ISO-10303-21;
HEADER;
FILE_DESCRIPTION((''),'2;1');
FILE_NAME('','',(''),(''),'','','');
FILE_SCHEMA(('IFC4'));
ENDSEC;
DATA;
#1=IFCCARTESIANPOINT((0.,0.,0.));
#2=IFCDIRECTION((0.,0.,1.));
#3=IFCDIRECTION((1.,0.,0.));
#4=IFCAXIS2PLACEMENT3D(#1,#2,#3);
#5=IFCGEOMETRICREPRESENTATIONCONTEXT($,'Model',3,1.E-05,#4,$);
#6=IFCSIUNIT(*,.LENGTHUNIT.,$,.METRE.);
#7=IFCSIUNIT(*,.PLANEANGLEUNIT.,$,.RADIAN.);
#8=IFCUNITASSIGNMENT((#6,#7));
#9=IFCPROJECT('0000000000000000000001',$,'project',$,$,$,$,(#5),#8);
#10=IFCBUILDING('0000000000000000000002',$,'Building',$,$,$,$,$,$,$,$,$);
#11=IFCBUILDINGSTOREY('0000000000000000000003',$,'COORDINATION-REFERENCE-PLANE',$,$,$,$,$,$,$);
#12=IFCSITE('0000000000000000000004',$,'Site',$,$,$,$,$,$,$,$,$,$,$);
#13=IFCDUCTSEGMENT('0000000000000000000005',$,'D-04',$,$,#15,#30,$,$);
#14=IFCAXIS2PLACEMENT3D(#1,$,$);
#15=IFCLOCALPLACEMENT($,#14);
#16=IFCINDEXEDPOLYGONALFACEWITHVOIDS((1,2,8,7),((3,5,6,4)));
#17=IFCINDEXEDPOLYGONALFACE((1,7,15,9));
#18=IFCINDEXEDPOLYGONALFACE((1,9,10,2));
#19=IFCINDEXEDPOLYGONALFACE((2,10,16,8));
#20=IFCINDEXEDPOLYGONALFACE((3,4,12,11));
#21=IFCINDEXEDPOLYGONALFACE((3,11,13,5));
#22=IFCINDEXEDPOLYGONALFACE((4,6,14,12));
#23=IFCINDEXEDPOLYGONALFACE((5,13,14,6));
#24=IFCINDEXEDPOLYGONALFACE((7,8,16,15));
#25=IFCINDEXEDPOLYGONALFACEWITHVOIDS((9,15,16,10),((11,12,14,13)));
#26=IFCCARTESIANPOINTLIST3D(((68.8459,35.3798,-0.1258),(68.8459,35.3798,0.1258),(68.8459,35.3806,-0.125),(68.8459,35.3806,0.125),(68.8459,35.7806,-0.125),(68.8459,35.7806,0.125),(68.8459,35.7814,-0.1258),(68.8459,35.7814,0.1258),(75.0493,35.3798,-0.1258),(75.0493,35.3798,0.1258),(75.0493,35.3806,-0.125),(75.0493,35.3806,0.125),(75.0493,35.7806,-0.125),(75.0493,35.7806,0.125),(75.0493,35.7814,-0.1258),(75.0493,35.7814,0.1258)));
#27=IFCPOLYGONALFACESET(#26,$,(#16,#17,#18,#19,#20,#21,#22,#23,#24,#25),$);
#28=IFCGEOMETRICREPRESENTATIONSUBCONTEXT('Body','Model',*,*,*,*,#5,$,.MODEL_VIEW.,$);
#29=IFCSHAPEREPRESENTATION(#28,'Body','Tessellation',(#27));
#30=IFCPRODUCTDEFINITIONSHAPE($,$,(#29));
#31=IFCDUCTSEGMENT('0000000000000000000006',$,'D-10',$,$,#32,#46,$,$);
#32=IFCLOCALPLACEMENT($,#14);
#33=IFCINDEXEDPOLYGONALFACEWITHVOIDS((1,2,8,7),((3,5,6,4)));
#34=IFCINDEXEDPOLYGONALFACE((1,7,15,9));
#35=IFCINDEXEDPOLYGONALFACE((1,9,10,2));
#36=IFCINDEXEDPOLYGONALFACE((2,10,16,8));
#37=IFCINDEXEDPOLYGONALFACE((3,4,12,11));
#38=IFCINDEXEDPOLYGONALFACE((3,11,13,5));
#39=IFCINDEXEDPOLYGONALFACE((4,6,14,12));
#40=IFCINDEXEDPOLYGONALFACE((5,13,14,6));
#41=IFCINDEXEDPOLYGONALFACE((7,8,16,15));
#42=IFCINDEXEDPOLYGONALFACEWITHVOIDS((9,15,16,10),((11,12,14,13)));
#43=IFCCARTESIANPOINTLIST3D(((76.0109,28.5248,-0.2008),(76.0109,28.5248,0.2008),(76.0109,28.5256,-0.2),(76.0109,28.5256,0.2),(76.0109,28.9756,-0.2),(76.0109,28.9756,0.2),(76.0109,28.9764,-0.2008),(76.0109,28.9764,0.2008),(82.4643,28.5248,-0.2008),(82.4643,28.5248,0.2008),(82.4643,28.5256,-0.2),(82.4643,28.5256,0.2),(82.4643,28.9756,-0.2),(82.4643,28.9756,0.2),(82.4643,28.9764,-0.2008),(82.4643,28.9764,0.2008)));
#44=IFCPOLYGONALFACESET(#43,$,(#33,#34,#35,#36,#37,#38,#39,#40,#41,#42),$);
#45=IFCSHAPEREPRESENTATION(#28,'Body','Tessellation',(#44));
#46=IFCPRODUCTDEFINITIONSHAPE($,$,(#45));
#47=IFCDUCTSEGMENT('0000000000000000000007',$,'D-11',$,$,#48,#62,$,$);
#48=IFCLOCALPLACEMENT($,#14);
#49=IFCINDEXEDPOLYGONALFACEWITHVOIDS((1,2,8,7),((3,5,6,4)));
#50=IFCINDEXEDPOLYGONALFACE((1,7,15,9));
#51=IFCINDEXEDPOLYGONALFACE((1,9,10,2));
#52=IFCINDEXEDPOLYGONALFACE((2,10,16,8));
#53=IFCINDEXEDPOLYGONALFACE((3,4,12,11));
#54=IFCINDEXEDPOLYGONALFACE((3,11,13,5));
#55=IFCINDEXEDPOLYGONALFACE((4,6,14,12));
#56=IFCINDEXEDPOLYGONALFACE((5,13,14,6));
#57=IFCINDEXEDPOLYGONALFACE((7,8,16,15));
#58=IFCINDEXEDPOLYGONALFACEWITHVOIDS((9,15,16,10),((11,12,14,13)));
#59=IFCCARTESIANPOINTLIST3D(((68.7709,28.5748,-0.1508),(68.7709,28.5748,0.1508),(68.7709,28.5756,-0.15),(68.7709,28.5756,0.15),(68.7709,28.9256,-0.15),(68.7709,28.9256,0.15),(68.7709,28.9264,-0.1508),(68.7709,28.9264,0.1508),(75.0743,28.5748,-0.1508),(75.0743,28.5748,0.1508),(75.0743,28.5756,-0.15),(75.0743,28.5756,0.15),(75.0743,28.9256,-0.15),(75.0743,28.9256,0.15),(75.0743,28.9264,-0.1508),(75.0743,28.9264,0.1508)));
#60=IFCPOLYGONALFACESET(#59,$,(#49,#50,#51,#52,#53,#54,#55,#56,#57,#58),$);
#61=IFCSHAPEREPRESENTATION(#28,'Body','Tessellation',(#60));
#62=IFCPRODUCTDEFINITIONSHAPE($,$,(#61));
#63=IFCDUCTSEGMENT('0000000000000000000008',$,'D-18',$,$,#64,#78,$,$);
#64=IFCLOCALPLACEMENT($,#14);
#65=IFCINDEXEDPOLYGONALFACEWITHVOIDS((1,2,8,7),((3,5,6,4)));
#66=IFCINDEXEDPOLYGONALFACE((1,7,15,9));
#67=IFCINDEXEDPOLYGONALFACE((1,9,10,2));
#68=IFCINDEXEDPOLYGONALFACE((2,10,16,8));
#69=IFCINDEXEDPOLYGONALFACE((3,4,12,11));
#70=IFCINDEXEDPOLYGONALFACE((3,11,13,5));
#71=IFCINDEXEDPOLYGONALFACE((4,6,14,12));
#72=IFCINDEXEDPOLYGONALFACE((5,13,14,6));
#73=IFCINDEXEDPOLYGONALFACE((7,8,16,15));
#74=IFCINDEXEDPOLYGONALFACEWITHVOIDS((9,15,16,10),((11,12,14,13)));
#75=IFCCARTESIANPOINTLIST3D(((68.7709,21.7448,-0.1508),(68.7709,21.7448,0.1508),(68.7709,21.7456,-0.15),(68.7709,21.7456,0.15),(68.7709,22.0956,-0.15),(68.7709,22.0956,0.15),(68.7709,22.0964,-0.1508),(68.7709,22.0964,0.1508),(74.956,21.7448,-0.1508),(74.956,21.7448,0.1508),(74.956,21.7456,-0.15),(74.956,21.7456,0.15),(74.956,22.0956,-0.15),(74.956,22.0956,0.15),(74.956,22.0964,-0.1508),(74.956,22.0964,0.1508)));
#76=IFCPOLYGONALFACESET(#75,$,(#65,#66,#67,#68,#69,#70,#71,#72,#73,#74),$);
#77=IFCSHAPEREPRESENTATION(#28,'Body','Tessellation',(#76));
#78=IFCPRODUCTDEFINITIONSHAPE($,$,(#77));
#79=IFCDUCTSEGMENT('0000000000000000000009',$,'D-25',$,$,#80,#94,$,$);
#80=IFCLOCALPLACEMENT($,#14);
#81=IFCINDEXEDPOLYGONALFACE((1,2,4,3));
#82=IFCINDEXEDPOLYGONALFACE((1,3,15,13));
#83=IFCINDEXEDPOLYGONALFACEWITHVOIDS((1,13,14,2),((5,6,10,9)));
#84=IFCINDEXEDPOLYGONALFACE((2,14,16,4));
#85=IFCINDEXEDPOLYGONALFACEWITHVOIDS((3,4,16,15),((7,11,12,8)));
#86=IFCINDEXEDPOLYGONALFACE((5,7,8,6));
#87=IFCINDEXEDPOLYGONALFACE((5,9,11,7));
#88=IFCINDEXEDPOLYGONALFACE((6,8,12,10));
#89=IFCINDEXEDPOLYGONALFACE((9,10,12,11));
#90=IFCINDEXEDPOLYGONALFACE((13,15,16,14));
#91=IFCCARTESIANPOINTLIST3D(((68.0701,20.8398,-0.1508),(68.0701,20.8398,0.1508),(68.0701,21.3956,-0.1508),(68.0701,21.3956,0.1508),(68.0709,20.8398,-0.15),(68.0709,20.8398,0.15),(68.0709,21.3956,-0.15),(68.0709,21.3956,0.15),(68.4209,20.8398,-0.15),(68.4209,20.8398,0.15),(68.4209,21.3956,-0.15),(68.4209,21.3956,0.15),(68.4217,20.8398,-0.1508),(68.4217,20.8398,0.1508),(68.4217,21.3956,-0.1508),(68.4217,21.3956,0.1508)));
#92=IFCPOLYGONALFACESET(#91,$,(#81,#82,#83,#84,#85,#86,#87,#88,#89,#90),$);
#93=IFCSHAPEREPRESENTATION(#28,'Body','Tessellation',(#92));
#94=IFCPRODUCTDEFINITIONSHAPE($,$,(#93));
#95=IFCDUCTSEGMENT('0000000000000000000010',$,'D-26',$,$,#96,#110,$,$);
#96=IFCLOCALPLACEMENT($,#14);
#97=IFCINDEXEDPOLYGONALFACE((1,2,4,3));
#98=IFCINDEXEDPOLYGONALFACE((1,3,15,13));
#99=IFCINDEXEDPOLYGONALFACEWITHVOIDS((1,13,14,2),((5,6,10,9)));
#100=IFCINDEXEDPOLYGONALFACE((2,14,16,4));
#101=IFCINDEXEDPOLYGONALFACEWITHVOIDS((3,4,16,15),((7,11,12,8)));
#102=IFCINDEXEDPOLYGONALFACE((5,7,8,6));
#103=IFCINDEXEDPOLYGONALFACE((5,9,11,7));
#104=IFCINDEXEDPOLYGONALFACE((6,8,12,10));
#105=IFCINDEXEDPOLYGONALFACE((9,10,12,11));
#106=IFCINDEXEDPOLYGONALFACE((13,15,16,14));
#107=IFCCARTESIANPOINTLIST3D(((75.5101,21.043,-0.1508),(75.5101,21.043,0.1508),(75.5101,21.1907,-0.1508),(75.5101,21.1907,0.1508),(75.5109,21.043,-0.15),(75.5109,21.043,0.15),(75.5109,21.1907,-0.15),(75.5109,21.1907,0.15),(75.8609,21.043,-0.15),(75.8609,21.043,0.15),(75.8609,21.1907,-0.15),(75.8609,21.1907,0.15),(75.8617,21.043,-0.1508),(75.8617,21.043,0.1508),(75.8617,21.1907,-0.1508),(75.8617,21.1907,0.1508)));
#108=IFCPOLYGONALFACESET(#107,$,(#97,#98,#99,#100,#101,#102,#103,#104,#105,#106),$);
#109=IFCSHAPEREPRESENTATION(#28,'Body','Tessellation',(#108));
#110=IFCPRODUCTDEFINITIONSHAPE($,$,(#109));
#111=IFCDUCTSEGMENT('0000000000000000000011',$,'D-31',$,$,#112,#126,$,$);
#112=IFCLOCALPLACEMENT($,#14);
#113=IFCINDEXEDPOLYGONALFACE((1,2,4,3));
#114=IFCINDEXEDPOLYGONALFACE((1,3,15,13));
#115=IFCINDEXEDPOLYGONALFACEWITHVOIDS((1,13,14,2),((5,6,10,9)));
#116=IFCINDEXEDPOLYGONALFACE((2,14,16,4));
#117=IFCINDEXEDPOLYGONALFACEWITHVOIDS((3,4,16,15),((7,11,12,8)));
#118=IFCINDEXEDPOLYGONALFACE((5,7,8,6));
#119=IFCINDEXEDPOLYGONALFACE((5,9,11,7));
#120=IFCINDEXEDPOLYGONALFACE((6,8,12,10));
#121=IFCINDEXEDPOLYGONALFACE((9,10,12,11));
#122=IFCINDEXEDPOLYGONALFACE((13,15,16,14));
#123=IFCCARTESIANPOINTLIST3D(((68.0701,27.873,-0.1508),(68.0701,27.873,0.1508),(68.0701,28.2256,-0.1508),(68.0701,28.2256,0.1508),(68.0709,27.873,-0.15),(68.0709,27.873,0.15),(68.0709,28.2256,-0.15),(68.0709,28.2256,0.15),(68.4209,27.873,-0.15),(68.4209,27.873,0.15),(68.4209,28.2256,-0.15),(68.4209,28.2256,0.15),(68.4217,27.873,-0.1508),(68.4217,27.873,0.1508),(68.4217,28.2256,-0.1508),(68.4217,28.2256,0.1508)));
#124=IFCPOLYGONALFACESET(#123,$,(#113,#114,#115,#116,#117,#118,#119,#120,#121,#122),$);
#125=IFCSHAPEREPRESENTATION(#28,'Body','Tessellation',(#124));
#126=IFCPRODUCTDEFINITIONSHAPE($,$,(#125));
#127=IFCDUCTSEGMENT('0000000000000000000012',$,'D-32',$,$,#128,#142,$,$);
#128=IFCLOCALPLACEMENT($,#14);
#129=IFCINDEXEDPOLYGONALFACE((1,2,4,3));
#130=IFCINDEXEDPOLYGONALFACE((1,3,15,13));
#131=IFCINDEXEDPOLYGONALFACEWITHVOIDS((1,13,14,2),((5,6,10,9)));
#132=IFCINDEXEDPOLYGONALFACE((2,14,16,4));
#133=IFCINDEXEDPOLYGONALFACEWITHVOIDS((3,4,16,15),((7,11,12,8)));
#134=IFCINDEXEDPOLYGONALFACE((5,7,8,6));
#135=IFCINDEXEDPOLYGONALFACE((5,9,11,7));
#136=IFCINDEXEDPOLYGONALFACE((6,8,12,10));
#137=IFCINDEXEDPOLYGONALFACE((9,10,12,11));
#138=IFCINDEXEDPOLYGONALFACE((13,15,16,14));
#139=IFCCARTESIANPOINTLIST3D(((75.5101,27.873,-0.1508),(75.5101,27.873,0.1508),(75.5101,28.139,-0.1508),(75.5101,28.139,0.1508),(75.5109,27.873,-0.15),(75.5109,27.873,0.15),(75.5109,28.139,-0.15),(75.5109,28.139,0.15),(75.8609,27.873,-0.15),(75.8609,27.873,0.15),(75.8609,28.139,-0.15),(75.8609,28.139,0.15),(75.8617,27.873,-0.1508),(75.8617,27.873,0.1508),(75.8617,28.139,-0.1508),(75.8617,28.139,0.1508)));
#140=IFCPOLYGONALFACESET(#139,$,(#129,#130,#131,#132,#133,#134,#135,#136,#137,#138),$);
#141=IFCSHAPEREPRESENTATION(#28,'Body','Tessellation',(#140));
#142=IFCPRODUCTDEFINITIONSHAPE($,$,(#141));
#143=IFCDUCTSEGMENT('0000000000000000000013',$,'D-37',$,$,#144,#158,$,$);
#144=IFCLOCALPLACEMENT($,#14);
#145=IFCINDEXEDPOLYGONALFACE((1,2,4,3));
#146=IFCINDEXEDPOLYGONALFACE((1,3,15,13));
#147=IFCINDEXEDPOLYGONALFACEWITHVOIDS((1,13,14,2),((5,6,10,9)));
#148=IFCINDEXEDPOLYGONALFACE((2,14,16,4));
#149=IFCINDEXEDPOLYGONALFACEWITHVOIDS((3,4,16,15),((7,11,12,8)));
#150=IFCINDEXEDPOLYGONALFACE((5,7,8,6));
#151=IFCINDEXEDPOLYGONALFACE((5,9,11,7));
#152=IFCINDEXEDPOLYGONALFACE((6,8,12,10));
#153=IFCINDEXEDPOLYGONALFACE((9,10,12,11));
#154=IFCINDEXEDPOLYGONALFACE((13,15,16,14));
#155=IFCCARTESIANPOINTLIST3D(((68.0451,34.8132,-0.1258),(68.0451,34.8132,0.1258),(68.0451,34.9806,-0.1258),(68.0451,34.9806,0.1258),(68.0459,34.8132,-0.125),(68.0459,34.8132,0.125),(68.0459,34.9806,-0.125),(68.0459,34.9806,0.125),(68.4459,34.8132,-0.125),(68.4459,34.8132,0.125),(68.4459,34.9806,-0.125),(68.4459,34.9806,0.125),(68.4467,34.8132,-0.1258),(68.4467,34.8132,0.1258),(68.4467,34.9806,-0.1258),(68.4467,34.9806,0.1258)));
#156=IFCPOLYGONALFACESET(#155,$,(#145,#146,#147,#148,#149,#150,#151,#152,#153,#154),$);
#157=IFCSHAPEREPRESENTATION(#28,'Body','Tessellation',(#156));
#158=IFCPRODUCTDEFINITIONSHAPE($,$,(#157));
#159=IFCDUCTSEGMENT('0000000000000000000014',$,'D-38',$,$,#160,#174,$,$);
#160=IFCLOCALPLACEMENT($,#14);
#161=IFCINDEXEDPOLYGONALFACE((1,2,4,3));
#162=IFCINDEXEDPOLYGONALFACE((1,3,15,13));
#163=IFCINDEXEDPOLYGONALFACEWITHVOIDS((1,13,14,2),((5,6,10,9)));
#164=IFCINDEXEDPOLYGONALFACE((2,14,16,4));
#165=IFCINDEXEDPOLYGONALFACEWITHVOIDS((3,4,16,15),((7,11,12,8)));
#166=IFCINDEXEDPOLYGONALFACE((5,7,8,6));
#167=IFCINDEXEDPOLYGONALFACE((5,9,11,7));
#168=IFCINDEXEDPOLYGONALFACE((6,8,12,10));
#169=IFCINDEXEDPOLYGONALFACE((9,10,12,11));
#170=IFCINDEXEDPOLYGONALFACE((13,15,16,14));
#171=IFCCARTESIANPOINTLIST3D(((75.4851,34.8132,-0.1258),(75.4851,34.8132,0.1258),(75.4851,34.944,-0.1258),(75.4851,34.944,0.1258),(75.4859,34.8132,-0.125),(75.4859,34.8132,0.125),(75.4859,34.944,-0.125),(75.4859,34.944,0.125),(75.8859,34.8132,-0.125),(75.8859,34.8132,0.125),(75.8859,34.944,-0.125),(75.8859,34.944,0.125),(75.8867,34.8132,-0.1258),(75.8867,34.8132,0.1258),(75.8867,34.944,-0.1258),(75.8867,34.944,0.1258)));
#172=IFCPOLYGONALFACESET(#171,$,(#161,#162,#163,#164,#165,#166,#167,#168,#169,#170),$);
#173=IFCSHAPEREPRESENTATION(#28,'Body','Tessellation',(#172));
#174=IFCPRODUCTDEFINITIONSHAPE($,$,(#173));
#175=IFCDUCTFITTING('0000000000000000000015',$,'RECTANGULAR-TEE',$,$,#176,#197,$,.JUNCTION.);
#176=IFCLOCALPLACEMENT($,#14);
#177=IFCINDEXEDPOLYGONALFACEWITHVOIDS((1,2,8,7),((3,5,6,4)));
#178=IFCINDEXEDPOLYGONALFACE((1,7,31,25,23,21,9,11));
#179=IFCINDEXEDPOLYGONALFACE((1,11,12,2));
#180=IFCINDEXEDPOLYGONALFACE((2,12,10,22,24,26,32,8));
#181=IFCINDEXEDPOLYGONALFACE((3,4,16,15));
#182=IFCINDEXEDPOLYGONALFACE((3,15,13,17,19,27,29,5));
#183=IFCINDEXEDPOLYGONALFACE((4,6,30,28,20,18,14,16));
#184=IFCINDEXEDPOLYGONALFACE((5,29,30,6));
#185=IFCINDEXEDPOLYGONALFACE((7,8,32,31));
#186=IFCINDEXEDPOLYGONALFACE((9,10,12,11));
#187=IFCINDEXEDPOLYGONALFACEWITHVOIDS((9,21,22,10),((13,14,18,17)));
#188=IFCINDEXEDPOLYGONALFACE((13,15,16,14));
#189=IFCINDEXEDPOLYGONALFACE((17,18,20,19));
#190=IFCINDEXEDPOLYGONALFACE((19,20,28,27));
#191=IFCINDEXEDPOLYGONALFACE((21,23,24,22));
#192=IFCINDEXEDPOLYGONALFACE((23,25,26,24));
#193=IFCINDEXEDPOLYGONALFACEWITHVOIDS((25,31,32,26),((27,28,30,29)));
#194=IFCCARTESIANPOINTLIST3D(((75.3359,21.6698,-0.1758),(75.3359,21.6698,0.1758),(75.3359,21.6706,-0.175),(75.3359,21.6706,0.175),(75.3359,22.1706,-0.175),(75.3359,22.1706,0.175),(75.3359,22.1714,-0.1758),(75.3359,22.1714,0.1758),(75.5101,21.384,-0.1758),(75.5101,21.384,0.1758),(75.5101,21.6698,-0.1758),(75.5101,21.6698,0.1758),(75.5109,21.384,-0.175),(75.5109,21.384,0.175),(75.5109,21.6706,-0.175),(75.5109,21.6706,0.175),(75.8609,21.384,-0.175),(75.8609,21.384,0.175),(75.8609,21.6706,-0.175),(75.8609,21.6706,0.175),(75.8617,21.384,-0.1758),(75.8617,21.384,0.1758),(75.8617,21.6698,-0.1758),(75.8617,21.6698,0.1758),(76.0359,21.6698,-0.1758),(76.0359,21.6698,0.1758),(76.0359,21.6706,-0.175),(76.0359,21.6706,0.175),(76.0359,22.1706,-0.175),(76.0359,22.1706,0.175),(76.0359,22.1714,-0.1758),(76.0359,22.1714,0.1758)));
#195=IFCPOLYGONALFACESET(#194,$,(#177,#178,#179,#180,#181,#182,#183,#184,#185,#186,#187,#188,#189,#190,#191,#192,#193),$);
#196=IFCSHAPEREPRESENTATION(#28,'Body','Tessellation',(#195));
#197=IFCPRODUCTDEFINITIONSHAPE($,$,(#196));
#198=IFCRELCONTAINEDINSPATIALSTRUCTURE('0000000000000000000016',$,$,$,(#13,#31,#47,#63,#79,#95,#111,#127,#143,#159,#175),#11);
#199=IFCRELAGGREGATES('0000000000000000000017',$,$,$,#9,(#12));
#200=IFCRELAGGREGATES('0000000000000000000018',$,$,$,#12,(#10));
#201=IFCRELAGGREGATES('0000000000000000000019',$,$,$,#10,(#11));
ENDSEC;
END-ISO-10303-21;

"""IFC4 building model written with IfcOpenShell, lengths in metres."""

from ifc_helpers import new_model, si_unit, frame, origin, origin_with_axes, place, context, subcontext, project, spatial, rectangle, hollow_rectangle, extrude, boolean, element, save


model = new_model("IFC4")

# Units and contexts
model_context = context("Model", 3, precision=1e-05, world=origin_with_axes())
body_context_1 = subcontext(model_context, "Body", "Model", "MODEL_VIEW")
ifc_project = project(units=[si_unit("LENGTHUNIT", "METRE"), si_unit("PLANEANGLEUNIT", "RADIAN")], contexts=[model_context])

# Site, building, storey
site = spatial("IfcSite", under=ifc_project, Name="Site")
building = spatial("IfcBuilding", under=site, Name="Building")
storey = spatial("IfcBuildingStorey", under=building, Name="COORDINATION-REFERENCE-PLANE")

# Duct segments
duct_segment_1_placement = place(None, frame((68.8459, 35.5806, 0.0), z_axis=(1.0, 0.0, 0.0), x_axis=(0.0, 1.0, 0.0)))
element("IfcDuctSegment", 1, at=duct_segment_1_placement, inside=storey, Name="D-04", context=body_context_1, shape_type="SweptSolid", body=[
    extrude(hollow_rectangle(XDim=0.4016, YDim=0.2516, WallThickness=0.0008), origin(), (0.0, 0.0, 1.0), 6.2034),
])
duct_segment_2_placement = place(None, frame((76.0109, 28.7506, 0.0), z_axis=(1.0, 0.0, 0.0), x_axis=(0.0, 1.0, 0.0)))
element("IfcDuctSegment", 2, at=duct_segment_2_placement, inside=storey, Name="D-10", context=body_context_1, shape_type="SweptSolid", body=[
    extrude(hollow_rectangle(XDim=0.4516, YDim=0.4016, WallThickness=0.0008), origin(), (0.0, 0.0, 1.0), 6.4534),
])
duct_segment_3_placement = place(None, frame((68.7709, 28.7506, 0.0), z_axis=(1.0, 0.0, 0.0), x_axis=(0.0, 1.0, 0.0)))
element("IfcDuctSegment", 3, at=duct_segment_3_placement, inside=storey, Name="D-11", context=body_context_1, shape_type="SweptSolid", body=[
    extrude(hollow_rectangle(XDim=0.3516, YDim=0.3016, WallThickness=0.0008), origin(), (0.0, 0.0, 1.0), 6.3034),
])
duct_segment_4_placement = place(None, frame((68.7709, 21.9206, 0.0), z_axis=(1.0, 0.0, 0.0), x_axis=(0.0, 1.0, 0.0)))
element("IfcDuctSegment", 4, at=duct_segment_4_placement, inside=storey, Name="D-18", context=body_context_1, shape_type="SweptSolid", body=[
    extrude(hollow_rectangle(XDim=0.3516, YDim=0.3016, WallThickness=0.0008), origin(), (0.0, 0.0, 1.0), 6.1851),
])
duct_segment_5_placement = place(None, frame((68.2459, 20.8398, 0.0), z_axis=(0.0, 1.0, 0.0), x_axis=(1.0, 0.0, 0.0)))
element("IfcDuctSegment", 5, at=duct_segment_5_placement, inside=storey, Name="D-25", context=body_context_1, shape_type="SweptSolid", body=[
    extrude(hollow_rectangle(XDim=0.3516, YDim=0.3016, WallThickness=0.0008), origin(), (0.0, 0.0, 1.0), 0.5558),
])
duct_segment_6_placement = place(None, frame((75.6859, 21.043, 0.0), z_axis=(0.0, 1.0, 0.0), x_axis=(1.0, 0.0, 0.0)))
element("IfcDuctSegment", 6, at=duct_segment_6_placement, inside=storey, Name="D-26", context=body_context_1, shape_type="SweptSolid", body=[
    extrude(hollow_rectangle(XDim=0.3516, YDim=0.3016, WallThickness=0.0008), origin(), (0.0, 0.0, 1.0), 0.1477),
])
duct_segment_7_placement = place(None, frame((68.2459, 27.873, 0.0), z_axis=(0.0, 1.0, 0.0), x_axis=(1.0, 0.0, 0.0)))
element("IfcDuctSegment", 7, at=duct_segment_7_placement, inside=storey, Name="D-31", context=body_context_1, shape_type="SweptSolid", body=[
    extrude(hollow_rectangle(XDim=0.3516, YDim=0.3016, WallThickness=0.0008), origin(), (0.0, 0.0, 1.0), 0.3526),
])
duct_segment_8_placement = place(None, frame((75.6859, 27.873, 0.0), z_axis=(0.0, 1.0, 0.0), x_axis=(1.0, 0.0, 0.0)))
element("IfcDuctSegment", 8, at=duct_segment_8_placement, inside=storey, Name="D-32", context=body_context_1, shape_type="SweptSolid", body=[
    extrude(hollow_rectangle(XDim=0.3516, YDim=0.3016, WallThickness=0.0008), origin(), (0.0, 0.0, 1.0), 0.266),
])
duct_segment_9_placement = place(None, frame((68.2459, 34.8132, 0.0), z_axis=(0.0, 1.0, 0.0), x_axis=(1.0, 0.0, 0.0)))
element("IfcDuctSegment", 9, at=duct_segment_9_placement, inside=storey, Name="D-37", context=body_context_1, shape_type="SweptSolid", body=[
    extrude(hollow_rectangle(XDim=0.4016, YDim=0.2516, WallThickness=0.0008), origin(), (0.0, 0.0, 1.0), 0.1673),
])
duct_segment_10_placement = place(None, frame((75.6859, 34.8132, 0.0), z_axis=(0.0, 1.0, 0.0), x_axis=(1.0, 0.0, 0.0)))
element("IfcDuctSegment", 10, at=duct_segment_10_placement, inside=storey, Name="D-38", context=body_context_1, shape_type="SweptSolid", body=[
    extrude(hollow_rectangle(XDim=0.4016, YDim=0.2516, WallThickness=0.0008), origin(), (0.0, 0.0, 1.0), 0.1307),
])

# Duct fitting
duct_fitting_1_placement = place(None, frame((75.6859, 21.9206, 0.0), z_axis=(-1.0, 0.0, 0.0), x_axis=(0.0, -1.0, 0.0)))
solid_1 = boolean("UNION", extrude(rectangle(XDim=0.5, YDim=0.35), frame((0.0, 0.0, -0.35), z_axis=(0.0, 0.0, 1.0), x_axis=(1.0, 0.0, 0.0)), (0.0, 0.0, 1.0), 0.7), extrude(rectangle(XDim=0.35, YDim=0.35), frame((0.0, 0.0, 0.0), z_axis=(1.0, 0.0, 0.0), x_axis=(0.0, 0.0, -1.0)), (0.0, 0.0, 1.0), 0.5366))
element("IfcDuctFitting", 11, at=duct_fitting_1_placement, inside=storey, Name="RECTANGULAR-TEE", PredefinedType="JUNCTION", context=body_context_1, shape_type="CSG", body=[
    boolean("DIFFERENCE", boolean("UNION", extrude(rectangle(XDim=0.5016, YDim=0.3516), frame((0.0, 0.0, -0.35), z_axis=(0.0, 0.0, 1.0), x_axis=(1.0, 0.0, 0.0)), (0.0, 0.0, 1.0), 0.7), extrude(rectangle(XDim=0.3516, YDim=0.3516), frame((0.0, 0.0, 0.0), z_axis=(1.0, 0.0, 0.0), x_axis=(0.0, 0.0, -1.0)), (0.0, 0.0, 1.0), 0.5366)), solid_1),
])

save(model, "model.ifc")
